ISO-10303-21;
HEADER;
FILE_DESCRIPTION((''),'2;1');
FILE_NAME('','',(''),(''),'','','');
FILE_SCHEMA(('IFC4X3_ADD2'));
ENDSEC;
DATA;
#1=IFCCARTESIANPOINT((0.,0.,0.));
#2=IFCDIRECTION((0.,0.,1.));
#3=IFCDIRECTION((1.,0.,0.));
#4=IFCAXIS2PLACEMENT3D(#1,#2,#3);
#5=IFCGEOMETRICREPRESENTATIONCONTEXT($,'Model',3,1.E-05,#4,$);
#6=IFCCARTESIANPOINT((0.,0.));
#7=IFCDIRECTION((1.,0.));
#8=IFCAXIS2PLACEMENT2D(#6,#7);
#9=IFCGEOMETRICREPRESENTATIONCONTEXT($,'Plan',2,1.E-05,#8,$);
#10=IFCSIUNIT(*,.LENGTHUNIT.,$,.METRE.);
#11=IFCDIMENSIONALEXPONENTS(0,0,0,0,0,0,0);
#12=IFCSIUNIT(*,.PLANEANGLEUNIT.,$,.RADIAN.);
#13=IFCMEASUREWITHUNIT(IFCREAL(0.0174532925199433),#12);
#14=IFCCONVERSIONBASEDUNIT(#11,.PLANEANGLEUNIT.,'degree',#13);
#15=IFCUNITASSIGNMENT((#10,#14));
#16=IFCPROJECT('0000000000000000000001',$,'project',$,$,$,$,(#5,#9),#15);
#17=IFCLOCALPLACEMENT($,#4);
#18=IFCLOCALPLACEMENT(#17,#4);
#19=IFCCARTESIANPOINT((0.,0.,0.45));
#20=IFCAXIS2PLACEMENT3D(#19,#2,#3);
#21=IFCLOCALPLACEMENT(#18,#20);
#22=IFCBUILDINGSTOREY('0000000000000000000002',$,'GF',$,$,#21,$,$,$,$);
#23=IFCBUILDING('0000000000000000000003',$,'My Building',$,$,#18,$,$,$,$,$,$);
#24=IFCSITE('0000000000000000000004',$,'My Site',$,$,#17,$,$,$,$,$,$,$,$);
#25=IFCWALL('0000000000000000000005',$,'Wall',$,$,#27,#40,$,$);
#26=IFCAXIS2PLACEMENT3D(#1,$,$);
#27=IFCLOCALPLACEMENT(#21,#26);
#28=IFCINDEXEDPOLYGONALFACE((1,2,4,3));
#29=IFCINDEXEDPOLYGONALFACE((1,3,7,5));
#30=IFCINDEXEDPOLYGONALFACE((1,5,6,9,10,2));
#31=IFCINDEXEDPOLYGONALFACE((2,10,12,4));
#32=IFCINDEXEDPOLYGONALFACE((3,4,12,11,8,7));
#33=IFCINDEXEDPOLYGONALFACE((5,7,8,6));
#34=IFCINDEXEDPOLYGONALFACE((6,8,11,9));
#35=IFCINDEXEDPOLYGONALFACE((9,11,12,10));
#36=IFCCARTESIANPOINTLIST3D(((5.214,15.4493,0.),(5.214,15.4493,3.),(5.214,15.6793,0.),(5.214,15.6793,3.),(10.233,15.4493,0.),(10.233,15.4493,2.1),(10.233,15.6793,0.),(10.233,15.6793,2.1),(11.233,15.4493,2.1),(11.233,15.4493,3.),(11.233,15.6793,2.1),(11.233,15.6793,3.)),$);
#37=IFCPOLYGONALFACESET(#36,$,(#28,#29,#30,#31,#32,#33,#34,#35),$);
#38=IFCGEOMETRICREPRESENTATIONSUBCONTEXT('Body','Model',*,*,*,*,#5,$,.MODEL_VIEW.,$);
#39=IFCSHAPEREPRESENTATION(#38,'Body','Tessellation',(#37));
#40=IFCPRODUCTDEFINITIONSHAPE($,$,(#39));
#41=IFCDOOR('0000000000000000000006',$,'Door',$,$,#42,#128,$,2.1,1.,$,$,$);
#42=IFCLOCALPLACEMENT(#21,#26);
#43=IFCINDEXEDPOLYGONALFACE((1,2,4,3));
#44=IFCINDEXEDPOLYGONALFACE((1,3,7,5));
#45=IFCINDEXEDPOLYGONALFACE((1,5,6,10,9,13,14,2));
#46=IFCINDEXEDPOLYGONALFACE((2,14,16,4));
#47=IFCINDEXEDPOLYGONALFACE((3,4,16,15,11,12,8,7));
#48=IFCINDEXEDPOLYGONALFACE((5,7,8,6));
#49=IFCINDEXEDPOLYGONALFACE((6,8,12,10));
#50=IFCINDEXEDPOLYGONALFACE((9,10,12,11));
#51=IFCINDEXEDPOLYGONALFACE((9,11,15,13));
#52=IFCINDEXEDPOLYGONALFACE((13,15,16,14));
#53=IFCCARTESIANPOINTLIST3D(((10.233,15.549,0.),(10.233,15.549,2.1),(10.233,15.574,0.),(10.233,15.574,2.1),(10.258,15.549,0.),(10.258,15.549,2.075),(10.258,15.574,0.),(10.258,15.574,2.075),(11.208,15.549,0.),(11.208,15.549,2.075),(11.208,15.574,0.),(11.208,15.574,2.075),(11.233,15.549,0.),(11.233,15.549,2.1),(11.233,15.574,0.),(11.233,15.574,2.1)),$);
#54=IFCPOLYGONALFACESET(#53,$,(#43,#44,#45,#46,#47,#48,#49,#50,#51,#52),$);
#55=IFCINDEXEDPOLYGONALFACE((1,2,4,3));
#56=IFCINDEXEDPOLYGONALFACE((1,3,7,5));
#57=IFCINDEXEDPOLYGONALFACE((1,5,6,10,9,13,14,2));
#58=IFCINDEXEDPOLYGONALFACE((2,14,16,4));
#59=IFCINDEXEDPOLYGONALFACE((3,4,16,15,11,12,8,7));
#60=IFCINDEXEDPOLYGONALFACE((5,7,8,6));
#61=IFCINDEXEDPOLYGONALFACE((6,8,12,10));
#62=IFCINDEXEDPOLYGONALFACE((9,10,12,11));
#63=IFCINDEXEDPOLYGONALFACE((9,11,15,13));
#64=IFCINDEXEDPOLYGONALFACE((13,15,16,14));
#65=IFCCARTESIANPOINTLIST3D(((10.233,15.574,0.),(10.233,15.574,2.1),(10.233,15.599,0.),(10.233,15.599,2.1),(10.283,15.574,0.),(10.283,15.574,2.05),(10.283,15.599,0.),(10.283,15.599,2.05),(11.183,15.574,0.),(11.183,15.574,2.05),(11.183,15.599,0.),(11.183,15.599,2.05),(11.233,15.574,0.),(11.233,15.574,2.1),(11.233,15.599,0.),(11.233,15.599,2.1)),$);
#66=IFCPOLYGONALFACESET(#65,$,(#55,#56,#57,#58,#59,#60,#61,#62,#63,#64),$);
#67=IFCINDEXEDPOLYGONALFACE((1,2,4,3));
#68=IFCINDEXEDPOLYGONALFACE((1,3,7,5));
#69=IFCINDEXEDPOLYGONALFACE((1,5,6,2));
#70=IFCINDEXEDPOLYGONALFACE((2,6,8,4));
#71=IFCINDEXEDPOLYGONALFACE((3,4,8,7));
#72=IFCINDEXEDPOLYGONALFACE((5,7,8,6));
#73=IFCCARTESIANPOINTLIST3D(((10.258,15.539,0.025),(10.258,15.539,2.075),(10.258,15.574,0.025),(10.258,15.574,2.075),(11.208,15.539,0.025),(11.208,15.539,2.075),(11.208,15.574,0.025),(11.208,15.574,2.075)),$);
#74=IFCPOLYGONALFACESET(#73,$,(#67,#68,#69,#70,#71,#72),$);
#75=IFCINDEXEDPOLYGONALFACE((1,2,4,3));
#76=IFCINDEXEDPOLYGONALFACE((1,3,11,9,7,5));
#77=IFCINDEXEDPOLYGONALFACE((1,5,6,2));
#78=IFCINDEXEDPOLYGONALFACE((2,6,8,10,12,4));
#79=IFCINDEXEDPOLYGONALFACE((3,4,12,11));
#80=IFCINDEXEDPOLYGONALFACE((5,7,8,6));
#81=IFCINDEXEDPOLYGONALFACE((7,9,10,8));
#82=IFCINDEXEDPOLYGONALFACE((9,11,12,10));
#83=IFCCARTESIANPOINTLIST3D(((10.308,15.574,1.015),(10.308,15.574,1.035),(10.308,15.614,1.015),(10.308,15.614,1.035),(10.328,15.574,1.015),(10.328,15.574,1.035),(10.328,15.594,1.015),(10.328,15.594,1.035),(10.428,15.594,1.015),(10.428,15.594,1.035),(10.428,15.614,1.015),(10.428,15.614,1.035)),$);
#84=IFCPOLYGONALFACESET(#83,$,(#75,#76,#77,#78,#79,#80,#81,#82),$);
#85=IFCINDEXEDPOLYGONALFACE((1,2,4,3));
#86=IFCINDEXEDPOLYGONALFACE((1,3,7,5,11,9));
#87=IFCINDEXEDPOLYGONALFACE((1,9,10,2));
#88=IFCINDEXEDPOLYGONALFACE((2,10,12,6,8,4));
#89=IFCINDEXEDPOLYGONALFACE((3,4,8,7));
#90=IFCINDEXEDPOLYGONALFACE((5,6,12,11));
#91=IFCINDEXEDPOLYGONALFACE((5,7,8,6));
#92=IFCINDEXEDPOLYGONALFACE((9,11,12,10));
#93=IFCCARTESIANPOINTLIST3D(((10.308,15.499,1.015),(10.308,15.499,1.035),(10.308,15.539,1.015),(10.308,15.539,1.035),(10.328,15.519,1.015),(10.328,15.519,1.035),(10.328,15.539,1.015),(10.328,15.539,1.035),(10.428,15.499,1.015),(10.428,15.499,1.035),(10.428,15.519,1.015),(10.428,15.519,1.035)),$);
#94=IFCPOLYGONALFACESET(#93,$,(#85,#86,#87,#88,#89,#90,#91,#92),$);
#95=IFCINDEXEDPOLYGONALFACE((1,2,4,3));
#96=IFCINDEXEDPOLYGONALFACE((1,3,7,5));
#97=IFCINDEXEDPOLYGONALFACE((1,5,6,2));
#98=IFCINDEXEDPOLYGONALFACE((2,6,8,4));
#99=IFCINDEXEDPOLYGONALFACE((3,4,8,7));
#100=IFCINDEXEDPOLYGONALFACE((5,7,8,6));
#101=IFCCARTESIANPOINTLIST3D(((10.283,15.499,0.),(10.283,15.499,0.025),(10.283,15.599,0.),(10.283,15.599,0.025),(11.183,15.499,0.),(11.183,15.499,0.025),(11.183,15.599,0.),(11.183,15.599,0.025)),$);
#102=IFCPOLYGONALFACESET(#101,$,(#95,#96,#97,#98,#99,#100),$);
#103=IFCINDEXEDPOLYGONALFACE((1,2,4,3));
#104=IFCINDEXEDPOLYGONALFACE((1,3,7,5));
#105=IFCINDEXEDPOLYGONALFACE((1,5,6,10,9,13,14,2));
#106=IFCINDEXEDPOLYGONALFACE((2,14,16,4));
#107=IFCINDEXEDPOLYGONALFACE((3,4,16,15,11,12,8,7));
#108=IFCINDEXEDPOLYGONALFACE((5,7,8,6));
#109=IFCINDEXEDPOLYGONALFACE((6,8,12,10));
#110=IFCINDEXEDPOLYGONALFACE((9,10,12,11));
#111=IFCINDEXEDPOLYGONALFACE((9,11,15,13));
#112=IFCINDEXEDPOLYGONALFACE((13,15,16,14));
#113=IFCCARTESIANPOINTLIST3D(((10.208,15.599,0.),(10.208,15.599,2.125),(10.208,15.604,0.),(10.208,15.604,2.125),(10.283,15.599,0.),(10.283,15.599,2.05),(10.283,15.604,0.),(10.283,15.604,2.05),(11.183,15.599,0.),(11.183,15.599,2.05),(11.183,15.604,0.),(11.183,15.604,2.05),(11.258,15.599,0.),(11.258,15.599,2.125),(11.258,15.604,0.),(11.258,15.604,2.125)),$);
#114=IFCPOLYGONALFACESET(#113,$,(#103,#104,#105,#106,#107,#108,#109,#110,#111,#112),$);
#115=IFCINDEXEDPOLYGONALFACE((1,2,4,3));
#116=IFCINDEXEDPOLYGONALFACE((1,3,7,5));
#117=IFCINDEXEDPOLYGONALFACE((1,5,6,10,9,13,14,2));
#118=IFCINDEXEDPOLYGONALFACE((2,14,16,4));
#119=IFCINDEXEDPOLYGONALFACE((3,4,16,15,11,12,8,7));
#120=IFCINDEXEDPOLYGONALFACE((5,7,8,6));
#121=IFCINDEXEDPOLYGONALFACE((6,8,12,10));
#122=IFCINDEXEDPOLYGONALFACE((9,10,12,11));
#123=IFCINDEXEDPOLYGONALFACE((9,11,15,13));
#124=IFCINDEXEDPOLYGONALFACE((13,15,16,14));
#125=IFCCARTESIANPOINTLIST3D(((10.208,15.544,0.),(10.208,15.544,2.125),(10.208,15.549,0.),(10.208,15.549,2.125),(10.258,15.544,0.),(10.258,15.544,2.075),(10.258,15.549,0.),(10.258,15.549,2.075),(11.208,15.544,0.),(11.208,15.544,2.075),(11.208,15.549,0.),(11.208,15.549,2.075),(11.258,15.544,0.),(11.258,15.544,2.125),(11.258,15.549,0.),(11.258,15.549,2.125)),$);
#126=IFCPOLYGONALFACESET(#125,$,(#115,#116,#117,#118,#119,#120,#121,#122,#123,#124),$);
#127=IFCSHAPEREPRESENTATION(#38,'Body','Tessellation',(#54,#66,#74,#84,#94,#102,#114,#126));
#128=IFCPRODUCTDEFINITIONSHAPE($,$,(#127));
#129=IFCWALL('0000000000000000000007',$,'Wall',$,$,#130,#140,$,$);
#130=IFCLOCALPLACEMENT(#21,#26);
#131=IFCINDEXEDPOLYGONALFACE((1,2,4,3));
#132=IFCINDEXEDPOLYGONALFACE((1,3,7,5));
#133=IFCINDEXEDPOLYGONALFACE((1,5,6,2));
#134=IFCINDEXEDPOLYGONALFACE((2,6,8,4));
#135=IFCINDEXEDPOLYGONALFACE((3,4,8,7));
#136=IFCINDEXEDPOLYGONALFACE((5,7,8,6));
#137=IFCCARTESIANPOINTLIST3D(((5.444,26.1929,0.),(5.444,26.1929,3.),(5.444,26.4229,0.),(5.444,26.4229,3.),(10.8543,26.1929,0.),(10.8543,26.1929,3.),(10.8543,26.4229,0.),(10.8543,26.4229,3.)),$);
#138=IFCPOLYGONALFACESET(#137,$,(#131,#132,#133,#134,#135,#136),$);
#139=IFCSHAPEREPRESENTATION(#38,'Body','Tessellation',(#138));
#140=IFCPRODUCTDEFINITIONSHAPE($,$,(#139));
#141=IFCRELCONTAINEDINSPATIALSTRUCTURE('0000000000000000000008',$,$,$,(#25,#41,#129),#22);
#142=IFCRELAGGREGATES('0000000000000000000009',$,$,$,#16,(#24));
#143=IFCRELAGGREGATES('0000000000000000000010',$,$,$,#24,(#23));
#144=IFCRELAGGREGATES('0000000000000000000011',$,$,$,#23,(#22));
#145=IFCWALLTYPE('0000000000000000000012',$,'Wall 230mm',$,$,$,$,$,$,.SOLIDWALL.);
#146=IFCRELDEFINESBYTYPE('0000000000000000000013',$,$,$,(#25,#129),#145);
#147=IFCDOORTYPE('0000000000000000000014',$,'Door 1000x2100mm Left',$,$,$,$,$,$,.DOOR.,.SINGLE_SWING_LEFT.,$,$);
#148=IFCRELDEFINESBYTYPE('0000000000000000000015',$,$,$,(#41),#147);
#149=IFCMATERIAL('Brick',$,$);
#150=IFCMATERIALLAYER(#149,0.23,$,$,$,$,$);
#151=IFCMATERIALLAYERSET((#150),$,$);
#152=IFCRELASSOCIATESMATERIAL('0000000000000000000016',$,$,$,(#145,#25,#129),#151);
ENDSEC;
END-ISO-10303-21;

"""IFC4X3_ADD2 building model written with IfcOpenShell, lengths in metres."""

from ifc_helpers import new_model, entity, si_unit, converted_unit, frame, origin_with_axes, origin_2d_with_axis, place, context, subcontext, project, spatial, line, indexed_curve, outline, extrude, shape, source, transform, mapped, material, layer, layer_set, layer_usage, type_object, type_shapes, element, fill, save


model = new_model("IFC4X3_ADD2")

# Units and contexts
model_context = context("Model", 3, precision=1e-05, world=origin_with_axes())
plan_context = context("Plan", 2, precision=1e-05, world=origin_2d_with_axis())
body_context_1 = subcontext(model_context, "Body", "Model", "MODEL_VIEW")
body_context_2 = subcontext(plan_context, "Body", "Plan", "PLAN_VIEW")
ifc_project = project(units=[si_unit("LENGTHUNIT", "METRE"), converted_unit("PLANEANGLEUNIT", "degree", entity("IfcReal", 0.0174532925199433), si_unit("PLANEANGLEUNIT", "RADIAN"), dimensions=[0, 0, 0, 0, 0, 0, 0])], contexts=[model_context, plan_context])

# Site, building, storey
site_placement = place(None, origin_with_axes())
site = spatial("IfcSite", under=ifc_project, at=site_placement, Name="My Site")
building_placement = place(site_placement, origin_with_axes())
building = spatial("IfcBuilding", under=site, at=building_placement, Name="My Building")
storey_placement = place(building_placement, frame((0.0, 0.0, 0.45), z_axis=(0.0, 0.0, 1.0), x_axis=(1.0, 0.0, 0.0)))
storey = spatial("IfcBuildingStorey", under=building, at=storey_placement, Name="GF")

# Shared definitions
ifc_material = material(Name="Brick")
ifc_layer_1 = layer(ifc_material, 0.23)
ifc_layer_set_1 = layer_set([ifc_layer_1])
wall_type_1 = type_object("IfcWallType", Name="Wall 230mm", PredefinedType="SOLIDWALL", material=ifc_layer_set_1)

# Wall, opening, door
ifc_layer_usage_1 = layer_usage(ifc_layer_set_1, "AXIS2", "POSITIVE", 0.0)
wall_1_placement = place(storey_placement, frame((5.214, 15.4493, 0.0), z_axis=(0.0, 0.0, 1.0), x_axis=(1.0, 0.0, 0.0)))
wall_1 = element("IfcWall", 1, at=wall_1_placement, inside=storey, type_object=wall_type_1, material=ifc_layer_usage_1, Name="Wall", context=body_context_1, shape_type="SweptSolid", body=[
    extrude(outline(indexed_curve([(0.0, 0.0), (0.0, 0.23), (6.019, 0.23), (6.019, 0.0), (0.0, 0.0)], self_intersect=False)), origin_with_axes(), (0.0, 0.0, 1.0), 3.0),
])
shared_shape_1 = source(origin_with_axes(), body_context_1, "Body", "SweptSolid", [
    extrude(outline(indexed_curve([(0.0, 0.0), (1.0, 0.0), (1.0, 2.1), (0.0, 2.1)], segments=[line(1, 2, 3, 4, 1)])), frame((0.0, -0.6, 0.0), z_axis=(0.0, -1.0, 0.0), x_axis=(1.0, 0.0, 0.0)), (0.0, 0.0, -1.0), 1.2),
])
opening_1_placement = place(wall_1_placement, frame((6.019, 0.1497, 0.0), z_axis=(0.0, 0.0, 1.0), x_axis=(-1.0, 0.0, 0.0)))
opening_1 = element("IfcOpeningElement", 2, at=opening_1_placement, cuts=wall_1, PredefinedType="OPENING", context=body_context_1, shape_type="MappedRepresentation", body=[
    mapped(shared_shape_1, transform((0.0, 0.0, 0.0), x_axis=(1.0, 0.0, 0.0), y_axis=(0.0, 1.0, 0.0), z_axis=(0.0, 0.0, 1.0), scale=1.0)),
])
door_type_1 = type_object("IfcDoorType", Name="Door 1000x2100mm Left", OperationType="SINGLE_SWING_LEFT", PredefinedType="DOOR")
shared_shape_2 = source(origin_with_axes(), body_context_1, "Body", "SweptSolid", [
    extrude(outline(indexed_curve([(0.0, 0.0), (0.0, 2.1), (1.0, 2.1), (1.0, 0.0), (0.975, 0.0), (0.975, 2.075), (0.025, 2.075), (0.025, 0.0)], segments=[line(1, 2, 3, 4, 5, 6, 7, 8, 1)])), frame((0.0, 0.025, 0.0), z_axis=(0.0, -1.0, 0.0), x_axis=(1.0, 0.0, 0.0)), (0.0, 0.0, -1.0), 0.025),
    extrude(outline(indexed_curve([(0.0, 0.0), (0.0, 2.1), (1.0, 2.1), (1.0, 0.0), (0.95, 0.0), (0.95, 2.05), (0.05, 2.05), (0.05, 0.0)], segments=[line(1, 2, 3, 4, 5, 6, 7, 8, 1)])), frame((0.0, 0.0, 0.0), z_axis=(0.0, -1.0, 0.0), x_axis=(1.0, 0.0, 0.0)), (0.0, 0.0, -1.0), 0.025),
    extrude(outline(indexed_curve([(0.0, 0.0), (0.95, 0.0), (0.95, 0.035), (0.0, 0.035)], segments=[line(1, 2, 3, 4, 1)])), frame((0.025, 0.025, 0.025), z_axis=(0.0, 0.0, 1.0), x_axis=(1.0, 0.0, 0.0)), (0.0, 0.0, 1.0), 2.05),
    extrude(outline(indexed_curve([(0.0, 0.0), (0.0, -0.04), (-0.12, -0.04), (-0.12, -0.02), (-0.02, -0.02), (-0.02, 0.0)], segments=[line(1, 2, 3, 4, 5, 6, 1)])), frame((0.925, 0.025, 1.015), z_axis=(0.0, 0.0, 1.0), x_axis=(1.0, 0.0, 0.0)), (0.0, 0.0, 1.0), 0.02),
    extrude(outline(indexed_curve([(0.0, 0.0), (0.0, 0.04), (-0.12, 0.04), (-0.12, 0.02), (-0.02, 0.02), (-0.02, 0.0)], segments=[line(1, 2, 3, 4, 5, 6, 1)])), frame((0.925, 0.06, 1.015), z_axis=(0.0, 0.0, 1.0), x_axis=(1.0, 0.0, 0.0)), (0.0, 0.0, 1.0), 0.02),
    extrude(outline(indexed_curve([(0.0, 0.0), (0.9, 0.0), (0.9, 0.1), (0.0, 0.1)], segments=[line(1, 2, 3, 4, 1)])), frame((0.05, 0.0, 0.0), z_axis=(0.0, 0.0, 1.0), x_axis=(1.0, 0.0, 0.0)), (0.0, 0.0, 1.0), 0.025),
    extrude(outline(indexed_curve([(0.0, 0.0), (0.0, 2.125), (1.05, 2.125), (1.05, 0.0), (0.975, 0.0), (0.975, 2.05), (0.075, 2.05), (0.075, 0.0)], segments=[line(1, 2, 3, 4, 5, 6, 7, 8, 1)])), frame((-0.025, -0.005, 0.0), z_axis=(0.0, -1.0, 0.0), x_axis=(1.0, 0.0, 0.0)), (0.0, 0.0, -1.0), 0.005),
    extrude(outline(indexed_curve([(0.0, 0.0), (0.0, 2.125), (1.05, 2.125), (1.05, 0.0), (1.0, 0.0), (1.0, 2.075), (0.05, 2.075), (0.05, 0.0)], segments=[line(1, 2, 3, 4, 5, 6, 7, 8, 1)])), frame((-0.025, 0.05, 0.0), z_axis=(0.0, -1.0, 0.0), x_axis=(1.0, 0.0, 0.0)), (0.0, 0.0, -1.0), 0.005),
])
shared_shape_3 = source(origin_with_axes(), body_context_2, "Body", "Curve2D", [
    entity("IfcIndexedPolyCurve", entity("IfcCartesianPointList2D", [[0.0, 0.0], [0.0, 0.05], [0.025, 0.05], [0.025, 0.025], [0.05, 0.025], [0.05, 0.0]]), [entity("IfcLineIndex", [1, 2, 3, 4, 5, 6, 1])]),
    entity("IfcIndexedPolyCurve", entity("IfcCartesianPointList2D", [[1.0, 0.0], [1.0, 0.05], [0.975, 0.05], [0.975, 0.025], [0.95, 0.025], [0.95, 0.0]]), [entity("IfcLineIndex", [1, 2, 3, 4, 5, 6, 1])]),
    entity("IfcTrimmedCurve", entity("IfcEllipse", entity("IfcAxis2Placement2D", entity("IfcCartesianPoint", [0.06, 0.05]), entity("IfcDirection", [1.0, 0.0])), 0.915, 0.95), [entity("IfcCartesianPoint", [0.975, 0.05])], [entity("IfcCartesianPoint", [0.06, 1.0])], True, "CARTESIAN"),
    entity("IfcIndexedPolyCurve", entity("IfcCartesianPointList2D", [[0.025, 0.05], [0.06, 0.05], [0.06, 1.0], [0.025, 1.0]]), [entity("IfcLineIndex", [1, 2, 3, 4, 1])]),
])
type_shapes(door_type_1, [shared_shape_2, shared_shape_3])
door_1_placement = place(opening_1_placement, frame((0.0, 0.0, 0.0), z_axis=(0.0, 0.0, 1.0), x_axis=(1.0, 0.0, 0.0)))
door_1 = element("IfcDoor", 3, at=door_1_placement, inside=storey, type_object=door_type_1, Name="Door", OverallHeight=2.1, OverallWidth=1.0, shapes=[
    shape(body_context_1, "Body", "MappedRepresentation", [mapped(shared_shape_2, transform((0.0, 0.0, 0.0), x_axis=(1.0, 0.0, 0.0), y_axis=(0.0, 1.0, 0.0), z_axis=(0.0, 0.0, 1.0), scale=1.0))]),
    shape(body_context_2, "Body", "MappedRepresentation", [mapped(shared_shape_3, transform((0.0, 0.0, 0.0), x_axis=(1.0, 0.0, 0.0), y_axis=(0.0, 1.0, 0.0), z_axis=(0.0, 0.0, 1.0), scale=1.0))]),
])
fill(opening_1, door_1)

# Wall
ifc_layer_usage_2 = layer_usage(ifc_layer_set_1, "AXIS2", "POSITIVE", 0.0)
wall_2_placement = place(storey_placement, frame((5.444, 26.1929, 0.0), z_axis=(0.0, 0.0, 1.0), x_axis=(1.0, 0.0, 0.0)))
element("IfcWall", 4, at=wall_2_placement, inside=storey, type_object=wall_type_1, material=ifc_layer_usage_2, Name="Wall", context=body_context_1, shape_type="SweptSolid", body=[
    extrude(outline(indexed_curve([(0.0, 0.0), (0.0, 0.23), (5.4103, 0.23), (5.4103, 0.0), (0.0, 0.0)], self_intersect=False)), origin_with_axes(), (0.0, 0.0, 1.0), 3.0),
])

save(model, "model.ifc")
